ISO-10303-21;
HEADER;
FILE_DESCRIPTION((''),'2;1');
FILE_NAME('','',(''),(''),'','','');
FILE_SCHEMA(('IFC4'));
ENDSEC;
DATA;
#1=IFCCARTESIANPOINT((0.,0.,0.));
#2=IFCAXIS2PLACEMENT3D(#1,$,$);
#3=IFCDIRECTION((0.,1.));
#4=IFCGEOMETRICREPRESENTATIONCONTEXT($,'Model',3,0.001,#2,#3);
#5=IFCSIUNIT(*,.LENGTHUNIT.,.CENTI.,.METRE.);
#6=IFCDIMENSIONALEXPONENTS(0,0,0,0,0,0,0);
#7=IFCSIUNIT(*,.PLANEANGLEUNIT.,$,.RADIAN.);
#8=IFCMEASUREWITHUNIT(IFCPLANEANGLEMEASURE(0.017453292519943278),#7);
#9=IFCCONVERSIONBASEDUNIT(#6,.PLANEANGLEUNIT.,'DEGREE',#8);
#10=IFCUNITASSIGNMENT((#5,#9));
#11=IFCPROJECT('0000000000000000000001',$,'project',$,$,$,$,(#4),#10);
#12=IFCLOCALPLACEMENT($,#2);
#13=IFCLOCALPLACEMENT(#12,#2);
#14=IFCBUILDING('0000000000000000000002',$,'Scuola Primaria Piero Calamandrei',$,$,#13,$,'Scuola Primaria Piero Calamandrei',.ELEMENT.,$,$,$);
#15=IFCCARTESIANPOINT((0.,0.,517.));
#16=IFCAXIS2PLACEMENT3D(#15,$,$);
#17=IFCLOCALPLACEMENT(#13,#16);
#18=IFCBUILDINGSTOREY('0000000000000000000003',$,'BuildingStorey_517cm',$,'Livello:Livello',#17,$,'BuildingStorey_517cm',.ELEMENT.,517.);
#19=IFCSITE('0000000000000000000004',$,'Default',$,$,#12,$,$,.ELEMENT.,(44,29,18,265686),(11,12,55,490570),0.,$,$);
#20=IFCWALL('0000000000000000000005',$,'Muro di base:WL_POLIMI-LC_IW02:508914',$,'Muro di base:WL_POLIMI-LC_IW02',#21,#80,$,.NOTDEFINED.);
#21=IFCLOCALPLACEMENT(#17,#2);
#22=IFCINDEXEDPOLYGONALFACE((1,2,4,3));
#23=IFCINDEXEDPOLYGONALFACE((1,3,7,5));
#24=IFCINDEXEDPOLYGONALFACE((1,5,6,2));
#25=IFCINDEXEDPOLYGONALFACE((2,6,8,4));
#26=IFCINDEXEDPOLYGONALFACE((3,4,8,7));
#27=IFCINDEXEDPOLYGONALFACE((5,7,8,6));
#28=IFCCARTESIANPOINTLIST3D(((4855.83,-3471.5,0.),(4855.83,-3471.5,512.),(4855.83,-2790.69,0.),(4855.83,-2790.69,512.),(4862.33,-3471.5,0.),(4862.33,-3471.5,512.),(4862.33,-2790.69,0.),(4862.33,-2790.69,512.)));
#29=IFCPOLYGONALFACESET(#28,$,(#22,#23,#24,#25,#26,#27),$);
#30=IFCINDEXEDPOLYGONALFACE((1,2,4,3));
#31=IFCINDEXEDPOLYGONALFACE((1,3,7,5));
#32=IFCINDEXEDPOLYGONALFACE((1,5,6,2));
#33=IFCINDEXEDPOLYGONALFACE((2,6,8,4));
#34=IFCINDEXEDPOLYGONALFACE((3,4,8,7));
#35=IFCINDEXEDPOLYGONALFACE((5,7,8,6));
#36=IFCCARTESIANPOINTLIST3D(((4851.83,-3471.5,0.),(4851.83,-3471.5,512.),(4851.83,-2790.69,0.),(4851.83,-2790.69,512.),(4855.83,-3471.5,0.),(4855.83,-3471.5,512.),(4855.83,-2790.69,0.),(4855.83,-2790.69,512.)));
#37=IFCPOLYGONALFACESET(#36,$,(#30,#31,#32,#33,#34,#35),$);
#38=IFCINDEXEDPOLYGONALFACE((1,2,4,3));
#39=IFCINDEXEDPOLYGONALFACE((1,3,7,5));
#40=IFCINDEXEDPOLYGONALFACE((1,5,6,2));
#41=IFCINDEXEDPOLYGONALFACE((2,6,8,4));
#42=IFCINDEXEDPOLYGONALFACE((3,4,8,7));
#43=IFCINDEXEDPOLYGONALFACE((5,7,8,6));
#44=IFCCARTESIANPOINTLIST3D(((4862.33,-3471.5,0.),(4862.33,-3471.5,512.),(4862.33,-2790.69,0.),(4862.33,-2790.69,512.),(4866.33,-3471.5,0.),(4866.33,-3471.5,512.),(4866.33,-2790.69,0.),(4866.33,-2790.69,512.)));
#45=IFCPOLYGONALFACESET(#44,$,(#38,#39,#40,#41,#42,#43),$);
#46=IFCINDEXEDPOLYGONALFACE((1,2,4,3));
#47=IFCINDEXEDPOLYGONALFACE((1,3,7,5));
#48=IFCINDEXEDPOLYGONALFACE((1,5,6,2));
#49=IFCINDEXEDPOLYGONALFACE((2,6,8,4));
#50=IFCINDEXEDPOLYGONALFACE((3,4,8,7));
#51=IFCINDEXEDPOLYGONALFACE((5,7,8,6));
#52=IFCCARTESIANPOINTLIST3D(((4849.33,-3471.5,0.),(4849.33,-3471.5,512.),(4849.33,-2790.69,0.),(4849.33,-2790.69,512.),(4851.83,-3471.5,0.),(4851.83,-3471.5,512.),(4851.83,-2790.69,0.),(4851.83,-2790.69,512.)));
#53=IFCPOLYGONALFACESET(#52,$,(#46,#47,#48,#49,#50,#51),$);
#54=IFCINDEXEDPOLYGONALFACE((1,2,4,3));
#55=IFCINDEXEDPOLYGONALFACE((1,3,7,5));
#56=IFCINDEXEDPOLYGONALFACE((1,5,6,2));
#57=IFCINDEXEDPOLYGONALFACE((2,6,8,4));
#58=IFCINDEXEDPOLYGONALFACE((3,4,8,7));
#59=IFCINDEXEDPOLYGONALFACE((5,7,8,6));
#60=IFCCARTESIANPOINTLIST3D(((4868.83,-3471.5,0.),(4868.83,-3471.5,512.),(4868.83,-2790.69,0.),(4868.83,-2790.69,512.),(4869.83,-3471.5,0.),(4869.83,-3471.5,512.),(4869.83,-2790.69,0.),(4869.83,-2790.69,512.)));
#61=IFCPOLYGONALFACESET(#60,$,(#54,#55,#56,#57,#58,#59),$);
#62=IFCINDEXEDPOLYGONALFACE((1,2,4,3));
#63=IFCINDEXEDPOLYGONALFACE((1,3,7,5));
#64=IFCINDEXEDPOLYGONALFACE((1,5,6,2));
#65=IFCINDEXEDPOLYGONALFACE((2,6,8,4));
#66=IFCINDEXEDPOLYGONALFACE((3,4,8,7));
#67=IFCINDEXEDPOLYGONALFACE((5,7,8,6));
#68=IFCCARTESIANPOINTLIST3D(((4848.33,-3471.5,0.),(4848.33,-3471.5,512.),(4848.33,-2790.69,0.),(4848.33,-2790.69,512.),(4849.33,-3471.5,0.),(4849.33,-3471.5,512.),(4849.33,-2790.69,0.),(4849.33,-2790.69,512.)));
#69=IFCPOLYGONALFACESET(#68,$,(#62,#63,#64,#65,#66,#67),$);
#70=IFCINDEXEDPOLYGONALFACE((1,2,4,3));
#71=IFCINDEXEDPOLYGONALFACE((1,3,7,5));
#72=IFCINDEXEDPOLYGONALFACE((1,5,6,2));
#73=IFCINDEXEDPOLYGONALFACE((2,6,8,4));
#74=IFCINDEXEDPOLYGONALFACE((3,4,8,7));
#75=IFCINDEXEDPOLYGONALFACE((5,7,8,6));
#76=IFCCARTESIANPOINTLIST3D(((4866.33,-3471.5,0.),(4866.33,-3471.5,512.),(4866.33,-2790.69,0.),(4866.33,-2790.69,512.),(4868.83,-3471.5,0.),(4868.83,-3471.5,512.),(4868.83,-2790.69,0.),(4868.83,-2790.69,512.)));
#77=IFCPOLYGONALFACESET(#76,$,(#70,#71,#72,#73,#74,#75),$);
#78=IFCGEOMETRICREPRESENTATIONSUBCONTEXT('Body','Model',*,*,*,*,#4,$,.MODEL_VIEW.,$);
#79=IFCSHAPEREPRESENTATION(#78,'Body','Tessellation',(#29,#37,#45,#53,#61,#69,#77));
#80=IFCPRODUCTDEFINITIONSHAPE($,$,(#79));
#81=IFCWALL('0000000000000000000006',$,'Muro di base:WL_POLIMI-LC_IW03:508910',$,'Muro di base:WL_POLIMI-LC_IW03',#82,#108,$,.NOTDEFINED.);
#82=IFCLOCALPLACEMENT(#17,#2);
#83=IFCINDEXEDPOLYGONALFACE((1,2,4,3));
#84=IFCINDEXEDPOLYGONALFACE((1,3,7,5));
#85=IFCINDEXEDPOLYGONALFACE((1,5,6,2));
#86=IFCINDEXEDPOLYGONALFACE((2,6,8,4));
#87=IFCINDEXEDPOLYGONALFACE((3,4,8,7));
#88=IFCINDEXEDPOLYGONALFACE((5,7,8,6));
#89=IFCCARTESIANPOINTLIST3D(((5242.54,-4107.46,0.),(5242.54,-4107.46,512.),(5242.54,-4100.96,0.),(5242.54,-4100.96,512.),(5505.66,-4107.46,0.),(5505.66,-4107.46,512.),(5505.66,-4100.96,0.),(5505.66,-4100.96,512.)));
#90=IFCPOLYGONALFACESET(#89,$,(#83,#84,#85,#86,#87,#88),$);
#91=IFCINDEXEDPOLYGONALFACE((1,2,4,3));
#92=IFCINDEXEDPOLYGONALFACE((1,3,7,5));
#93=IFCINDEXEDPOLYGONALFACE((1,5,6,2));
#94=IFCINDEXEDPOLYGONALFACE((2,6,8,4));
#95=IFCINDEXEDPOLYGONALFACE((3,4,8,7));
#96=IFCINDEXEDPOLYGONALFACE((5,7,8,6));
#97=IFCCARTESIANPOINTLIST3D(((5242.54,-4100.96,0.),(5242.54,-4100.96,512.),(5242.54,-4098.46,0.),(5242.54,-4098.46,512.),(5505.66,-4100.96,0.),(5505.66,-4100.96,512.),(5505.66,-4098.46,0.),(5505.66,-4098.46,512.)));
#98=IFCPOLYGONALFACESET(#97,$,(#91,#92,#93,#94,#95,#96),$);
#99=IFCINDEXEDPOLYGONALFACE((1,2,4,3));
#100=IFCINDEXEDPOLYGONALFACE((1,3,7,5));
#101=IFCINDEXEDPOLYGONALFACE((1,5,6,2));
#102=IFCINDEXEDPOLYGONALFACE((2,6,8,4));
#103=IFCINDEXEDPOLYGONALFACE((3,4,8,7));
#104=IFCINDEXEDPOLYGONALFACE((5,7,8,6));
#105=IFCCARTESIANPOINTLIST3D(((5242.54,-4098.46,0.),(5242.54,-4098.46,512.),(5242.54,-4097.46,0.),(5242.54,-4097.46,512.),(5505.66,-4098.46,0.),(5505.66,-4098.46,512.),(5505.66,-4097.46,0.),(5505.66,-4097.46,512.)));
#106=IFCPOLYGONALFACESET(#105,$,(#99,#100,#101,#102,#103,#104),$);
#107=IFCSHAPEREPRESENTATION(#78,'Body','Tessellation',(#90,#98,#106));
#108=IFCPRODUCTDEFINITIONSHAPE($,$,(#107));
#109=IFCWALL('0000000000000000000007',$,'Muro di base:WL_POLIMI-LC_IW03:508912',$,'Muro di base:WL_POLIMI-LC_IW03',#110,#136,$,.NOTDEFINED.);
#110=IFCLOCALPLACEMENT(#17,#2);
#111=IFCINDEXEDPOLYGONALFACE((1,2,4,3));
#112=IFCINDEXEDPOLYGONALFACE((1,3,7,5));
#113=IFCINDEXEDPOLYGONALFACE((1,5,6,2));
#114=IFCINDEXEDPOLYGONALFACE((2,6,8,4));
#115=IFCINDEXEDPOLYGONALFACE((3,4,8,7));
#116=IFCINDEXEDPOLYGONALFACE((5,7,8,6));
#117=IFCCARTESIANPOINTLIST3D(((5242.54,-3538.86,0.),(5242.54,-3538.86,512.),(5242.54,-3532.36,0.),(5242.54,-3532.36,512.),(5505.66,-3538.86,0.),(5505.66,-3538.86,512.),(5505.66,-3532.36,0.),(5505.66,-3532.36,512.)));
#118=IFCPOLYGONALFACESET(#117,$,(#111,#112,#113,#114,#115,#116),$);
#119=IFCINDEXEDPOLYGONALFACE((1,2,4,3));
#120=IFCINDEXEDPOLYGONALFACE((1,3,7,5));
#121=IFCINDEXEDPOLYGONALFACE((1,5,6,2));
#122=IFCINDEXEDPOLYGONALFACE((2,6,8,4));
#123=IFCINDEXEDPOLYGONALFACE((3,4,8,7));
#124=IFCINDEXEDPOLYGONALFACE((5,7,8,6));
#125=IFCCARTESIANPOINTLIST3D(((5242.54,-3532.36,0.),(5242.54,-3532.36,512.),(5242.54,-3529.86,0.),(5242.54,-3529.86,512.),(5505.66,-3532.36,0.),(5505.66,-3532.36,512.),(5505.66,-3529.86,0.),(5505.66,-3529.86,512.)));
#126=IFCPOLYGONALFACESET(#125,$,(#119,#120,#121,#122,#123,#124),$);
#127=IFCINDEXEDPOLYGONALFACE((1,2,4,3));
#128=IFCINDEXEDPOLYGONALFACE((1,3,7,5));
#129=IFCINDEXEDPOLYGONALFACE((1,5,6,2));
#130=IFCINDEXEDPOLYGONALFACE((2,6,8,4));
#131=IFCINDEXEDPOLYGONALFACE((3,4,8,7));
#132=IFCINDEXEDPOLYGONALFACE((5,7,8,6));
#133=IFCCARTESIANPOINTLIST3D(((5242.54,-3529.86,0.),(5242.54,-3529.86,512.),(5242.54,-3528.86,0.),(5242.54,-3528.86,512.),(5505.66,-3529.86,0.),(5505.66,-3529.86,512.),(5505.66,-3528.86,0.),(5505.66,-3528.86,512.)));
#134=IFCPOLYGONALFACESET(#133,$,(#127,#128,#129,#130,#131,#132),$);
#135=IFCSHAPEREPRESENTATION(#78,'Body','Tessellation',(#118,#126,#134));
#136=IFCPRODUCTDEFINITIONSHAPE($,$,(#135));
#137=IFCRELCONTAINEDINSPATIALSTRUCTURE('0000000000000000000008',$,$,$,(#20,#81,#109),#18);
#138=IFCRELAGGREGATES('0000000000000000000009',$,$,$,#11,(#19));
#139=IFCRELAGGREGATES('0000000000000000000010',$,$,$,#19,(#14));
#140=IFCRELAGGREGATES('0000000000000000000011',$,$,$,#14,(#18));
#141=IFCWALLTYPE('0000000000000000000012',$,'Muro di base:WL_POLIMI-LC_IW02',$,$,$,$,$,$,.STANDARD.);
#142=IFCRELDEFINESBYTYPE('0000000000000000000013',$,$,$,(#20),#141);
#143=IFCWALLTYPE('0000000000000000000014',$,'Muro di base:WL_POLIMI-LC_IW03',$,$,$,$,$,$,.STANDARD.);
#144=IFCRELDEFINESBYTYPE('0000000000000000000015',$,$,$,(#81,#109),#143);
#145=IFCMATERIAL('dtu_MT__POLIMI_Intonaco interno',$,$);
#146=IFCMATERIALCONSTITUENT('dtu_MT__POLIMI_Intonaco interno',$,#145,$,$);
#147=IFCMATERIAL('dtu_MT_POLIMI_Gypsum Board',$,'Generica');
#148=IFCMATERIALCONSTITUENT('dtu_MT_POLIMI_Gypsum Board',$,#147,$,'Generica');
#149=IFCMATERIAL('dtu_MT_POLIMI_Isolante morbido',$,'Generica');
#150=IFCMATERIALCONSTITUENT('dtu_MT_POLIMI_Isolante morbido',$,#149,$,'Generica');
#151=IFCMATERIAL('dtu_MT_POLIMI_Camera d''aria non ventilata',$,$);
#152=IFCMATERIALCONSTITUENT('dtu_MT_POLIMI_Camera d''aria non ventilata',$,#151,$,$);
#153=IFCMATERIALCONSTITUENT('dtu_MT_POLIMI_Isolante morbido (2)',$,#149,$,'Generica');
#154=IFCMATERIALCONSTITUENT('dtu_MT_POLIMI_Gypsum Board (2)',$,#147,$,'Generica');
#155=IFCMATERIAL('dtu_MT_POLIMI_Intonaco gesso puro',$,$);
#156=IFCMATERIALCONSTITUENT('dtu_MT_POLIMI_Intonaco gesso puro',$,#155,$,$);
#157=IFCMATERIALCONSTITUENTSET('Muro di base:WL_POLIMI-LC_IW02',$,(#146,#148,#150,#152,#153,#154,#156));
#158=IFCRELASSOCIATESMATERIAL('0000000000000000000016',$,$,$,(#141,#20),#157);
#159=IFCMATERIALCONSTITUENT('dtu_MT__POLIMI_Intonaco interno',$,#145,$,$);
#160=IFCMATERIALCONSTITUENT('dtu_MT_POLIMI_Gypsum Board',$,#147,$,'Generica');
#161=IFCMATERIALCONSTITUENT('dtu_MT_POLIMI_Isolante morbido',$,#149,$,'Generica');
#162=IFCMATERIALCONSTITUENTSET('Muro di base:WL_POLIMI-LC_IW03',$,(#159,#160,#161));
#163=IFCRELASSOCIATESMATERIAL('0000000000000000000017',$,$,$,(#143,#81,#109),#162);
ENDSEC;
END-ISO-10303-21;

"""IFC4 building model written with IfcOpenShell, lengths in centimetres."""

from ifc_helpers import new_model, entity, si_unit, converted_unit, direction, frame, origin, place, context, subcontext, project, spatial, indexed_curve, outline, extrude, material, constituent, constituent_set, type_object, element, save


model = new_model("IFC4")

# Units and contexts
model_context = context("Model", 3, precision=0.001, world=origin(), true_north=direction((0.0, 1.0)))
body_context = subcontext(model_context, "Body", "Model", "MODEL_VIEW")
ifc_project = project(units=[si_unit("LENGTHUNIT", "METRE", prefix="CENTI"), converted_unit("PLANEANGLEUNIT", "DEGREE", entity("IfcPlaneAngleMeasure", 0.017453292519943278), si_unit("PLANEANGLEUNIT", "RADIAN"), dimensions=[0, 0, 0, 0, 0, 0, 0])], contexts=[model_context])

# Site, building, storey
site_placement = place(None, origin())
site = spatial("IfcSite", under=ifc_project, at=site_placement, Name="Default", CompositionType="ELEMENT", RefLatitude=(44, 29, 18, 265686), RefLongitude=(11, 12, 55, 490570), RefElevation=0.0)
building_placement = place(site_placement, origin())
building = spatial("IfcBuilding", under=site, at=building_placement, Name="Scuola Primaria Piero Calamandrei", LongName="Scuola Primaria Piero Calamandrei", CompositionType="ELEMENT")
storey_placement = place(building_placement, frame((0.0, 0.0, 517.0)))
storey = spatial("IfcBuildingStorey", under=building, at=storey_placement, Name="BuildingStorey_517cm", ObjectType="Livello:Livello", LongName="BuildingStorey_517cm", CompositionType="ELEMENT", Elevation=517.0)

# Shared definitions
ifc_material_1 = material(Name="dtu_MT_POLIMI_Isolante morbido", Category="Generica")
ifc_material_2 = material(Name="dtu_MT_POLIMI_Gypsum Board", Category="Generica")
ifc_material_3 = material(Name="dtu_MT__POLIMI_Intonaco interno")

# Shared definitions
ifc_constituent_1 = constituent(ifc_material_3, Name="dtu_MT__POLIMI_Intonaco interno")
ifc_constituent_2 = constituent(ifc_material_2, Name="dtu_MT_POLIMI_Gypsum Board", Category="Generica")
ifc_constituent_3 = constituent(ifc_material_1, Name="dtu_MT_POLIMI_Isolante morbido", Category="Generica")
ifc_material_4 = material(Name="dtu_MT_POLIMI_Camera d'aria non ventilata")
ifc_constituent_4 = constituent(ifc_material_4, Name="dtu_MT_POLIMI_Camera d'aria non ventilata")
ifc_constituent_5 = constituent(ifc_material_1, Name="dtu_MT_POLIMI_Isolante morbido (2)", Category="Generica")
ifc_constituent_6 = constituent(ifc_material_2, Name="dtu_MT_POLIMI_Gypsum Board (2)", Category="Generica")
ifc_material_5 = material(Name="dtu_MT_POLIMI_Intonaco gesso puro")
ifc_constituent_7 = constituent(ifc_material_5, Name="dtu_MT_POLIMI_Intonaco gesso puro")
ifc_constituent_set_1 = constituent_set(constituents=[ifc_constituent_1, ifc_constituent_2, ifc_constituent_3, ifc_constituent_4, ifc_constituent_5, ifc_constituent_6, ifc_constituent_7], Name="Muro di base:WL_POLIMI-LC_IW02")
wall_type_1 = type_object("IfcWallType", Name="Muro di base:WL_POLIMI-LC_IW02", PredefinedType="STANDARD", material=ifc_constituent_set_1)

# Walls
wall_1_placement = place(storey_placement, frame((4859.08, -3471.5, 0.0), z_axis=(0.0, 0.0, 1.0), x_axis=(0.0, 1.0, 0.0)))
element("IfcWall", 1, at=wall_1_placement, inside=storey, type_object=wall_type_1, material=ifc_constituent_set_1, Name="Muro di base:WL_POLIMI-LC_IW02:508914", ObjectType="Muro di base:WL_POLIMI-LC_IW02", PredefinedType="NOTDEFINED", context=body_context, shape_type="SweptSolid", body=[
    extrude(outline(indexed_curve([(-340.41, -3.25), (340.41, -3.25), (340.41, 3.25), (-340.41, 3.25), (-340.41, -3.25)], self_intersect=False)), frame((340.41, 0.0, 0.0)), (0.0, 0.0, 1.0), 512.0),
    extrude(outline(indexed_curve([(-340.41, -2.0), (340.41, -2.0), (340.41, 2.0), (-340.41, 2.0), (-340.41, -2.0)], self_intersect=False)), frame((340.41, 5.25, 0.0)), (0.0, 0.0, 1.0), 512.0),
    extrude(outline(indexed_curve([(-340.41, -2.0), (340.41, -2.0), (340.41, 2.0), (-340.41, 2.0), (-340.41, -2.0)], self_intersect=False)), frame((340.41, -5.25, 0.0)), (0.0, 0.0, 1.0), 512.0),
    extrude(outline(indexed_curve([(-340.41, -1.25), (340.41, -1.25), (340.41, 1.25), (-340.41, 1.25), (-340.41, -1.25)], self_intersect=False)), frame((340.41, 8.5, 0.0)), (0.0, 0.0, 1.0), 512.0),
    extrude(outline(indexed_curve([(-0.5, -340.41), (0.5, -340.41), (0.5, 340.41), (-0.5, 340.41), (-0.5, -340.41)], self_intersect=False)), frame((340.41, -10.25, 0.0), z_axis=(0.0, 0.0, 1.0), x_axis=(0.0, 1.0, 0.0)), (0.0, 0.0, 1.0), 512.0),
    extrude(outline(indexed_curve([(-0.5, -340.41), (0.5, -340.41), (0.5, 340.41), (-0.5, 340.41), (-0.5, -340.41)], self_intersect=False)), frame((340.41, 10.25, 0.0), z_axis=(0.0, 0.0, 1.0), x_axis=(0.0, -1.0, 0.0)), (0.0, 0.0, 1.0), 512.0),
    extrude(outline(indexed_curve([(-340.41, -1.25), (340.41, -1.25), (340.41, 1.25), (-340.41, 1.25), (-340.41, -1.25)], self_intersect=False)), frame((340.41, -8.5, 0.0)), (0.0, 0.0, 1.0), 512.0),
])
ifc_constituent_8 = constituent(ifc_material_3, Name="dtu_MT__POLIMI_Intonaco interno")
ifc_constituent_9 = constituent(ifc_material_2, Name="dtu_MT_POLIMI_Gypsum Board", Category="Generica")
ifc_constituent_10 = constituent(ifc_material_1, Name="dtu_MT_POLIMI_Isolante morbido", Category="Generica")
ifc_constituent_set_2 = constituent_set(constituents=[ifc_constituent_8, ifc_constituent_9, ifc_constituent_10], Name="Muro di base:WL_POLIMI-LC_IW03")
wall_type_2 = type_object("IfcWallType", Name="Muro di base:WL_POLIMI-LC_IW03", PredefinedType="STANDARD", material=ifc_constituent_set_2)
wall_2_placement = place(storey_placement, frame((5242.54, -4102.46, 0.0)))
element("IfcWall", 2, at=wall_2_placement, inside=storey, type_object=wall_type_2, material=ifc_constituent_set_2, Name="Muro di base:WL_POLIMI-LC_IW03:508910", ObjectType="Muro di base:WL_POLIMI-LC_IW03", PredefinedType="NOTDEFINED", context=body_context, shape_type="SweptSolid", body=[
    extrude(outline(indexed_curve([(-3.25, -131.56), (3.25, -131.56), (3.25, 131.56), (-3.25, 131.56), (-3.25, -131.56)], self_intersect=False)), frame((131.56, -1.75, 0.0), z_axis=(0.0, 0.0, 1.0), x_axis=(0.0, 1.0, 0.0)), (0.0, 0.0, 1.0), 512.0),
    extrude(outline(indexed_curve([(-131.56, -1.25), (131.56, -1.25), (131.56, 1.25), (-131.56, 1.25), (-131.56, -1.25)], self_intersect=False)), frame((131.56, 2.75, 0.0)), (0.0, 0.0, 1.0), 512.0),
    extrude(outline(indexed_curve([(-0.5, -131.56), (0.5, -131.56), (0.5, 131.56), (-0.5, 131.56), (-0.5, -131.56)], self_intersect=False)), frame((131.56, 4.5, 0.0), z_axis=(0.0, 0.0, 1.0), x_axis=(0.0, -1.0, 0.0)), (0.0, 0.0, 1.0), 512.0),
])
wall_3_placement = place(storey_placement, frame((5242.54, -3533.86, 0.0)))
element("IfcWall", 3, at=wall_3_placement, inside=storey, type_object=wall_type_2, material=ifc_constituent_set_2, Name="Muro di base:WL_POLIMI-LC_IW03:508912", ObjectType="Muro di base:WL_POLIMI-LC_IW03", PredefinedType="NOTDEFINED", context=body_context, shape_type="SweptSolid", body=[
    extrude(outline(indexed_curve([(-3.25, -131.56), (3.25, -131.56), (3.25, 131.56), (-3.25, 131.56), (-3.25, -131.56)], self_intersect=False)), frame((131.56, -1.75, 0.0), z_axis=(0.0, 0.0, 1.0), x_axis=(0.0, 1.0, 0.0)), (0.0, 0.0, 1.0), 512.0),
    extrude(outline(indexed_curve([(-131.56, -1.25), (131.56, -1.25), (131.56, 1.25), (-131.56, 1.25), (-131.56, -1.25)], self_intersect=False)), frame((131.56, 2.75, 0.0)), (0.0, 0.0, 1.0), 512.0),
    extrude(outline(indexed_curve([(-0.5, -131.56), (0.5, -131.56), (0.5, 131.56), (-0.5, 131.56), (-0.5, -131.56)], self_intersect=False)), frame((131.56, 4.5, 0.0), z_axis=(0.0, 0.0, 1.0), x_axis=(0.0, -1.0, 0.0)), (0.0, 0.0, 1.0), 512.0),
])

save(model, "model.ifc")
